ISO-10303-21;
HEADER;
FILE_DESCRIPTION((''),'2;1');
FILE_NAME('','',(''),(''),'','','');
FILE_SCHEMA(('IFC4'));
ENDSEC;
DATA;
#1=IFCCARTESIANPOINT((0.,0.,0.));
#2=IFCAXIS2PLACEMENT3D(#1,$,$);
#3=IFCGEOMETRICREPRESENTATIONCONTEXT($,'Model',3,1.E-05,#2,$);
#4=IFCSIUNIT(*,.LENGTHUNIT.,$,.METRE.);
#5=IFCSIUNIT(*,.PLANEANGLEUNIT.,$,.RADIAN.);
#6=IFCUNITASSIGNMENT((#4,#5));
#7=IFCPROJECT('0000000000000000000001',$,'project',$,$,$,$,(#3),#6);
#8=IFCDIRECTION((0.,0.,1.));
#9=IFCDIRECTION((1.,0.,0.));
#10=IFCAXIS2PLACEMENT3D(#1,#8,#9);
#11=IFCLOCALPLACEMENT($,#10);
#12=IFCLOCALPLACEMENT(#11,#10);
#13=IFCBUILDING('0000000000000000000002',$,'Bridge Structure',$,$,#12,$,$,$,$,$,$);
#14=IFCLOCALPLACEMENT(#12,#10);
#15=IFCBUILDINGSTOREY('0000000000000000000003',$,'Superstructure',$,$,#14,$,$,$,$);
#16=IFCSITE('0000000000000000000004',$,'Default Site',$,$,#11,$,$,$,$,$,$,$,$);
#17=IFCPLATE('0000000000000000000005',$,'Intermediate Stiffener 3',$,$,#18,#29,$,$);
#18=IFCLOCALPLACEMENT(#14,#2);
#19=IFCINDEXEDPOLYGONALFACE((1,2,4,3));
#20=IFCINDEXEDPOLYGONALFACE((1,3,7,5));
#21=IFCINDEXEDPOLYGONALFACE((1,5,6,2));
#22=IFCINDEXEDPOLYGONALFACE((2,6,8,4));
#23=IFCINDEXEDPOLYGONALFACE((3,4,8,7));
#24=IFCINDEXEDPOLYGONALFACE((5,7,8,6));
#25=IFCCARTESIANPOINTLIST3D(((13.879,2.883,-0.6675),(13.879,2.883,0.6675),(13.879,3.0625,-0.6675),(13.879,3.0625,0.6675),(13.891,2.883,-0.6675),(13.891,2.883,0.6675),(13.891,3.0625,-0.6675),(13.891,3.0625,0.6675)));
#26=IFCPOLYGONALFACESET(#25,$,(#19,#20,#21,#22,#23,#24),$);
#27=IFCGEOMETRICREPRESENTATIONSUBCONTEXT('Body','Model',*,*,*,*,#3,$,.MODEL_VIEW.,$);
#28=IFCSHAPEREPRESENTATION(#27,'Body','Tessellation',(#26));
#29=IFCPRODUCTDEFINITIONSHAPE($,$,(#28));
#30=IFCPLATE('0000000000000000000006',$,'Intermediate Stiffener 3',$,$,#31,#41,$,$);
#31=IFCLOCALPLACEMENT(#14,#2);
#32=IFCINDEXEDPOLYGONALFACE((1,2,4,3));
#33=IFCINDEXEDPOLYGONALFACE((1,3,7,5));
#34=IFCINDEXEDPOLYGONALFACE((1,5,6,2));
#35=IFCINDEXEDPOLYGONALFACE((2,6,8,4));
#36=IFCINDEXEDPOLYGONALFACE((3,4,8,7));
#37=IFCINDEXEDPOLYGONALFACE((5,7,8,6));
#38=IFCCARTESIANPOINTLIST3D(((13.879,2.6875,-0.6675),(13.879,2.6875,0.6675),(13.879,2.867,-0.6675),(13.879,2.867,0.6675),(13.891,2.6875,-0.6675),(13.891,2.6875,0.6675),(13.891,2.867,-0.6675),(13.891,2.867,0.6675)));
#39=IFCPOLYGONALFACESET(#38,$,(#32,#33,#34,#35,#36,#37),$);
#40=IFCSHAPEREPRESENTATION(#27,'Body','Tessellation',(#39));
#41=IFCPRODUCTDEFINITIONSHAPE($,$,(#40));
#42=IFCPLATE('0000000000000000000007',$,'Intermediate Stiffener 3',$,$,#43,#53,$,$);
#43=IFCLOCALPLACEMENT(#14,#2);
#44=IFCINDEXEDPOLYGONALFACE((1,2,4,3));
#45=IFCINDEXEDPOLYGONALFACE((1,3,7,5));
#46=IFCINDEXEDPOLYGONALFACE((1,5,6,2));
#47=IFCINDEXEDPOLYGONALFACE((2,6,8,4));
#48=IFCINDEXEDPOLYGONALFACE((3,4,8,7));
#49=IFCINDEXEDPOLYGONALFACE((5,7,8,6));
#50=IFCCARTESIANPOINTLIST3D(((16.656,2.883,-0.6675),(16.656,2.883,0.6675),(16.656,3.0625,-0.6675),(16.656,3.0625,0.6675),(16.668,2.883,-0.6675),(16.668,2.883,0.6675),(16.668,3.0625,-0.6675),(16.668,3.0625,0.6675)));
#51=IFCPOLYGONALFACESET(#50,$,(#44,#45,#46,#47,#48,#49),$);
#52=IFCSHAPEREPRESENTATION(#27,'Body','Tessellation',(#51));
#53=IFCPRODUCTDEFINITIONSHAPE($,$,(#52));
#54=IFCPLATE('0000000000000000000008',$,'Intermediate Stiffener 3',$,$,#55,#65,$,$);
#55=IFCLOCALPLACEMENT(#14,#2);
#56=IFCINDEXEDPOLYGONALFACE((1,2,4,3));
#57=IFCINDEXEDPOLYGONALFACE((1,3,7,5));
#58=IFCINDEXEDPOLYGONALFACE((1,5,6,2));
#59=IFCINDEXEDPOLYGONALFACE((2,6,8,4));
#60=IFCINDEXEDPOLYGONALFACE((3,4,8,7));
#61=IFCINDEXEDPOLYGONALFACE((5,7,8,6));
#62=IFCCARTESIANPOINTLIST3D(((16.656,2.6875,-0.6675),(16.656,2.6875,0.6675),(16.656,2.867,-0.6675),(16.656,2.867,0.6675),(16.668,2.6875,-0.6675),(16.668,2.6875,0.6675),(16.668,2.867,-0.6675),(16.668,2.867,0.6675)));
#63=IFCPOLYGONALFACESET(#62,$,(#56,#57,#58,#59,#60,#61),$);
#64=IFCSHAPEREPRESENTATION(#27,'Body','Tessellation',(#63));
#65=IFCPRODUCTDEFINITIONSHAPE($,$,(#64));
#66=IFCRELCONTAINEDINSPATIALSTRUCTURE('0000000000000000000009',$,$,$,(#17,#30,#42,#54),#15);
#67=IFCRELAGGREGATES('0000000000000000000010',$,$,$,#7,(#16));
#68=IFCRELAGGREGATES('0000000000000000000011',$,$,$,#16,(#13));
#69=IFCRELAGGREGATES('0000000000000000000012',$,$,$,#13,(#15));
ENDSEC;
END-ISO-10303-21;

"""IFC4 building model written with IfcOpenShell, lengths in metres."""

from ifc_helpers import new_model, si_unit, frame, origin, origin_with_axes, origin_2d_with_axis, place, context, subcontext, project, spatial, rectangle, extrude, element, save


model = new_model("IFC4")

# Units and contexts
model_context = context("Model", 3, precision=1e-05, world=origin())
body_context = subcontext(model_context, "Body", "Model", "MODEL_VIEW")
ifc_project = project(units=[si_unit("LENGTHUNIT", "METRE"), si_unit("PLANEANGLEUNIT", "RADIAN")], contexts=[model_context])

# Site, building, storey
site_placement = place(None, origin_with_axes())
site = spatial("IfcSite", under=ifc_project, at=site_placement, Name="Default Site")
building_placement = place(site_placement, origin_with_axes())
building = spatial("IfcBuilding", under=site, at=building_placement, Name="Bridge Structure")
storey_placement = place(building_placement, origin_with_axes())
storey = spatial("IfcBuildingStorey", under=building, at=storey_placement, Name="Superstructure")

# Plates
for number, where, z_axis, x_axis, name in (
    (1, (13.885, 2.9728, -0.6675), (0.0, 0.0, 1.0), (1.0, 0.0, 0.0), "Intermediate Stiffener 3"),
    (2, (13.885, 2.7772, -0.6675), (0.0, 0.0, 1.0), (1.0, 0.0, 0.0), "Intermediate Stiffener 3"),
    (3, (16.662, 2.9728, -0.6675), (0.0, 0.0, 1.0), (1.0, 0.0, 0.0), "Intermediate Stiffener 3"),
    (4, (16.662, 2.7772, -0.6675), (0.0, 0.0, 1.0), (1.0, 0.0, 0.0), "Intermediate Stiffener 3"),
):
    element("IfcPlate", number, at=place(storey_placement, frame(where, z_axis=z_axis, x_axis=x_axis)), inside=storey, Name=name, context=body_context, shape_type="SweptSolid", body=[
        extrude(rectangle(XDim=0.012, YDim=0.1795, at=origin_2d_with_axis()), origin_with_axes(), (0.0, 0.0, 1.0), 1.335),
    ])

save(model, "model.ifc")
